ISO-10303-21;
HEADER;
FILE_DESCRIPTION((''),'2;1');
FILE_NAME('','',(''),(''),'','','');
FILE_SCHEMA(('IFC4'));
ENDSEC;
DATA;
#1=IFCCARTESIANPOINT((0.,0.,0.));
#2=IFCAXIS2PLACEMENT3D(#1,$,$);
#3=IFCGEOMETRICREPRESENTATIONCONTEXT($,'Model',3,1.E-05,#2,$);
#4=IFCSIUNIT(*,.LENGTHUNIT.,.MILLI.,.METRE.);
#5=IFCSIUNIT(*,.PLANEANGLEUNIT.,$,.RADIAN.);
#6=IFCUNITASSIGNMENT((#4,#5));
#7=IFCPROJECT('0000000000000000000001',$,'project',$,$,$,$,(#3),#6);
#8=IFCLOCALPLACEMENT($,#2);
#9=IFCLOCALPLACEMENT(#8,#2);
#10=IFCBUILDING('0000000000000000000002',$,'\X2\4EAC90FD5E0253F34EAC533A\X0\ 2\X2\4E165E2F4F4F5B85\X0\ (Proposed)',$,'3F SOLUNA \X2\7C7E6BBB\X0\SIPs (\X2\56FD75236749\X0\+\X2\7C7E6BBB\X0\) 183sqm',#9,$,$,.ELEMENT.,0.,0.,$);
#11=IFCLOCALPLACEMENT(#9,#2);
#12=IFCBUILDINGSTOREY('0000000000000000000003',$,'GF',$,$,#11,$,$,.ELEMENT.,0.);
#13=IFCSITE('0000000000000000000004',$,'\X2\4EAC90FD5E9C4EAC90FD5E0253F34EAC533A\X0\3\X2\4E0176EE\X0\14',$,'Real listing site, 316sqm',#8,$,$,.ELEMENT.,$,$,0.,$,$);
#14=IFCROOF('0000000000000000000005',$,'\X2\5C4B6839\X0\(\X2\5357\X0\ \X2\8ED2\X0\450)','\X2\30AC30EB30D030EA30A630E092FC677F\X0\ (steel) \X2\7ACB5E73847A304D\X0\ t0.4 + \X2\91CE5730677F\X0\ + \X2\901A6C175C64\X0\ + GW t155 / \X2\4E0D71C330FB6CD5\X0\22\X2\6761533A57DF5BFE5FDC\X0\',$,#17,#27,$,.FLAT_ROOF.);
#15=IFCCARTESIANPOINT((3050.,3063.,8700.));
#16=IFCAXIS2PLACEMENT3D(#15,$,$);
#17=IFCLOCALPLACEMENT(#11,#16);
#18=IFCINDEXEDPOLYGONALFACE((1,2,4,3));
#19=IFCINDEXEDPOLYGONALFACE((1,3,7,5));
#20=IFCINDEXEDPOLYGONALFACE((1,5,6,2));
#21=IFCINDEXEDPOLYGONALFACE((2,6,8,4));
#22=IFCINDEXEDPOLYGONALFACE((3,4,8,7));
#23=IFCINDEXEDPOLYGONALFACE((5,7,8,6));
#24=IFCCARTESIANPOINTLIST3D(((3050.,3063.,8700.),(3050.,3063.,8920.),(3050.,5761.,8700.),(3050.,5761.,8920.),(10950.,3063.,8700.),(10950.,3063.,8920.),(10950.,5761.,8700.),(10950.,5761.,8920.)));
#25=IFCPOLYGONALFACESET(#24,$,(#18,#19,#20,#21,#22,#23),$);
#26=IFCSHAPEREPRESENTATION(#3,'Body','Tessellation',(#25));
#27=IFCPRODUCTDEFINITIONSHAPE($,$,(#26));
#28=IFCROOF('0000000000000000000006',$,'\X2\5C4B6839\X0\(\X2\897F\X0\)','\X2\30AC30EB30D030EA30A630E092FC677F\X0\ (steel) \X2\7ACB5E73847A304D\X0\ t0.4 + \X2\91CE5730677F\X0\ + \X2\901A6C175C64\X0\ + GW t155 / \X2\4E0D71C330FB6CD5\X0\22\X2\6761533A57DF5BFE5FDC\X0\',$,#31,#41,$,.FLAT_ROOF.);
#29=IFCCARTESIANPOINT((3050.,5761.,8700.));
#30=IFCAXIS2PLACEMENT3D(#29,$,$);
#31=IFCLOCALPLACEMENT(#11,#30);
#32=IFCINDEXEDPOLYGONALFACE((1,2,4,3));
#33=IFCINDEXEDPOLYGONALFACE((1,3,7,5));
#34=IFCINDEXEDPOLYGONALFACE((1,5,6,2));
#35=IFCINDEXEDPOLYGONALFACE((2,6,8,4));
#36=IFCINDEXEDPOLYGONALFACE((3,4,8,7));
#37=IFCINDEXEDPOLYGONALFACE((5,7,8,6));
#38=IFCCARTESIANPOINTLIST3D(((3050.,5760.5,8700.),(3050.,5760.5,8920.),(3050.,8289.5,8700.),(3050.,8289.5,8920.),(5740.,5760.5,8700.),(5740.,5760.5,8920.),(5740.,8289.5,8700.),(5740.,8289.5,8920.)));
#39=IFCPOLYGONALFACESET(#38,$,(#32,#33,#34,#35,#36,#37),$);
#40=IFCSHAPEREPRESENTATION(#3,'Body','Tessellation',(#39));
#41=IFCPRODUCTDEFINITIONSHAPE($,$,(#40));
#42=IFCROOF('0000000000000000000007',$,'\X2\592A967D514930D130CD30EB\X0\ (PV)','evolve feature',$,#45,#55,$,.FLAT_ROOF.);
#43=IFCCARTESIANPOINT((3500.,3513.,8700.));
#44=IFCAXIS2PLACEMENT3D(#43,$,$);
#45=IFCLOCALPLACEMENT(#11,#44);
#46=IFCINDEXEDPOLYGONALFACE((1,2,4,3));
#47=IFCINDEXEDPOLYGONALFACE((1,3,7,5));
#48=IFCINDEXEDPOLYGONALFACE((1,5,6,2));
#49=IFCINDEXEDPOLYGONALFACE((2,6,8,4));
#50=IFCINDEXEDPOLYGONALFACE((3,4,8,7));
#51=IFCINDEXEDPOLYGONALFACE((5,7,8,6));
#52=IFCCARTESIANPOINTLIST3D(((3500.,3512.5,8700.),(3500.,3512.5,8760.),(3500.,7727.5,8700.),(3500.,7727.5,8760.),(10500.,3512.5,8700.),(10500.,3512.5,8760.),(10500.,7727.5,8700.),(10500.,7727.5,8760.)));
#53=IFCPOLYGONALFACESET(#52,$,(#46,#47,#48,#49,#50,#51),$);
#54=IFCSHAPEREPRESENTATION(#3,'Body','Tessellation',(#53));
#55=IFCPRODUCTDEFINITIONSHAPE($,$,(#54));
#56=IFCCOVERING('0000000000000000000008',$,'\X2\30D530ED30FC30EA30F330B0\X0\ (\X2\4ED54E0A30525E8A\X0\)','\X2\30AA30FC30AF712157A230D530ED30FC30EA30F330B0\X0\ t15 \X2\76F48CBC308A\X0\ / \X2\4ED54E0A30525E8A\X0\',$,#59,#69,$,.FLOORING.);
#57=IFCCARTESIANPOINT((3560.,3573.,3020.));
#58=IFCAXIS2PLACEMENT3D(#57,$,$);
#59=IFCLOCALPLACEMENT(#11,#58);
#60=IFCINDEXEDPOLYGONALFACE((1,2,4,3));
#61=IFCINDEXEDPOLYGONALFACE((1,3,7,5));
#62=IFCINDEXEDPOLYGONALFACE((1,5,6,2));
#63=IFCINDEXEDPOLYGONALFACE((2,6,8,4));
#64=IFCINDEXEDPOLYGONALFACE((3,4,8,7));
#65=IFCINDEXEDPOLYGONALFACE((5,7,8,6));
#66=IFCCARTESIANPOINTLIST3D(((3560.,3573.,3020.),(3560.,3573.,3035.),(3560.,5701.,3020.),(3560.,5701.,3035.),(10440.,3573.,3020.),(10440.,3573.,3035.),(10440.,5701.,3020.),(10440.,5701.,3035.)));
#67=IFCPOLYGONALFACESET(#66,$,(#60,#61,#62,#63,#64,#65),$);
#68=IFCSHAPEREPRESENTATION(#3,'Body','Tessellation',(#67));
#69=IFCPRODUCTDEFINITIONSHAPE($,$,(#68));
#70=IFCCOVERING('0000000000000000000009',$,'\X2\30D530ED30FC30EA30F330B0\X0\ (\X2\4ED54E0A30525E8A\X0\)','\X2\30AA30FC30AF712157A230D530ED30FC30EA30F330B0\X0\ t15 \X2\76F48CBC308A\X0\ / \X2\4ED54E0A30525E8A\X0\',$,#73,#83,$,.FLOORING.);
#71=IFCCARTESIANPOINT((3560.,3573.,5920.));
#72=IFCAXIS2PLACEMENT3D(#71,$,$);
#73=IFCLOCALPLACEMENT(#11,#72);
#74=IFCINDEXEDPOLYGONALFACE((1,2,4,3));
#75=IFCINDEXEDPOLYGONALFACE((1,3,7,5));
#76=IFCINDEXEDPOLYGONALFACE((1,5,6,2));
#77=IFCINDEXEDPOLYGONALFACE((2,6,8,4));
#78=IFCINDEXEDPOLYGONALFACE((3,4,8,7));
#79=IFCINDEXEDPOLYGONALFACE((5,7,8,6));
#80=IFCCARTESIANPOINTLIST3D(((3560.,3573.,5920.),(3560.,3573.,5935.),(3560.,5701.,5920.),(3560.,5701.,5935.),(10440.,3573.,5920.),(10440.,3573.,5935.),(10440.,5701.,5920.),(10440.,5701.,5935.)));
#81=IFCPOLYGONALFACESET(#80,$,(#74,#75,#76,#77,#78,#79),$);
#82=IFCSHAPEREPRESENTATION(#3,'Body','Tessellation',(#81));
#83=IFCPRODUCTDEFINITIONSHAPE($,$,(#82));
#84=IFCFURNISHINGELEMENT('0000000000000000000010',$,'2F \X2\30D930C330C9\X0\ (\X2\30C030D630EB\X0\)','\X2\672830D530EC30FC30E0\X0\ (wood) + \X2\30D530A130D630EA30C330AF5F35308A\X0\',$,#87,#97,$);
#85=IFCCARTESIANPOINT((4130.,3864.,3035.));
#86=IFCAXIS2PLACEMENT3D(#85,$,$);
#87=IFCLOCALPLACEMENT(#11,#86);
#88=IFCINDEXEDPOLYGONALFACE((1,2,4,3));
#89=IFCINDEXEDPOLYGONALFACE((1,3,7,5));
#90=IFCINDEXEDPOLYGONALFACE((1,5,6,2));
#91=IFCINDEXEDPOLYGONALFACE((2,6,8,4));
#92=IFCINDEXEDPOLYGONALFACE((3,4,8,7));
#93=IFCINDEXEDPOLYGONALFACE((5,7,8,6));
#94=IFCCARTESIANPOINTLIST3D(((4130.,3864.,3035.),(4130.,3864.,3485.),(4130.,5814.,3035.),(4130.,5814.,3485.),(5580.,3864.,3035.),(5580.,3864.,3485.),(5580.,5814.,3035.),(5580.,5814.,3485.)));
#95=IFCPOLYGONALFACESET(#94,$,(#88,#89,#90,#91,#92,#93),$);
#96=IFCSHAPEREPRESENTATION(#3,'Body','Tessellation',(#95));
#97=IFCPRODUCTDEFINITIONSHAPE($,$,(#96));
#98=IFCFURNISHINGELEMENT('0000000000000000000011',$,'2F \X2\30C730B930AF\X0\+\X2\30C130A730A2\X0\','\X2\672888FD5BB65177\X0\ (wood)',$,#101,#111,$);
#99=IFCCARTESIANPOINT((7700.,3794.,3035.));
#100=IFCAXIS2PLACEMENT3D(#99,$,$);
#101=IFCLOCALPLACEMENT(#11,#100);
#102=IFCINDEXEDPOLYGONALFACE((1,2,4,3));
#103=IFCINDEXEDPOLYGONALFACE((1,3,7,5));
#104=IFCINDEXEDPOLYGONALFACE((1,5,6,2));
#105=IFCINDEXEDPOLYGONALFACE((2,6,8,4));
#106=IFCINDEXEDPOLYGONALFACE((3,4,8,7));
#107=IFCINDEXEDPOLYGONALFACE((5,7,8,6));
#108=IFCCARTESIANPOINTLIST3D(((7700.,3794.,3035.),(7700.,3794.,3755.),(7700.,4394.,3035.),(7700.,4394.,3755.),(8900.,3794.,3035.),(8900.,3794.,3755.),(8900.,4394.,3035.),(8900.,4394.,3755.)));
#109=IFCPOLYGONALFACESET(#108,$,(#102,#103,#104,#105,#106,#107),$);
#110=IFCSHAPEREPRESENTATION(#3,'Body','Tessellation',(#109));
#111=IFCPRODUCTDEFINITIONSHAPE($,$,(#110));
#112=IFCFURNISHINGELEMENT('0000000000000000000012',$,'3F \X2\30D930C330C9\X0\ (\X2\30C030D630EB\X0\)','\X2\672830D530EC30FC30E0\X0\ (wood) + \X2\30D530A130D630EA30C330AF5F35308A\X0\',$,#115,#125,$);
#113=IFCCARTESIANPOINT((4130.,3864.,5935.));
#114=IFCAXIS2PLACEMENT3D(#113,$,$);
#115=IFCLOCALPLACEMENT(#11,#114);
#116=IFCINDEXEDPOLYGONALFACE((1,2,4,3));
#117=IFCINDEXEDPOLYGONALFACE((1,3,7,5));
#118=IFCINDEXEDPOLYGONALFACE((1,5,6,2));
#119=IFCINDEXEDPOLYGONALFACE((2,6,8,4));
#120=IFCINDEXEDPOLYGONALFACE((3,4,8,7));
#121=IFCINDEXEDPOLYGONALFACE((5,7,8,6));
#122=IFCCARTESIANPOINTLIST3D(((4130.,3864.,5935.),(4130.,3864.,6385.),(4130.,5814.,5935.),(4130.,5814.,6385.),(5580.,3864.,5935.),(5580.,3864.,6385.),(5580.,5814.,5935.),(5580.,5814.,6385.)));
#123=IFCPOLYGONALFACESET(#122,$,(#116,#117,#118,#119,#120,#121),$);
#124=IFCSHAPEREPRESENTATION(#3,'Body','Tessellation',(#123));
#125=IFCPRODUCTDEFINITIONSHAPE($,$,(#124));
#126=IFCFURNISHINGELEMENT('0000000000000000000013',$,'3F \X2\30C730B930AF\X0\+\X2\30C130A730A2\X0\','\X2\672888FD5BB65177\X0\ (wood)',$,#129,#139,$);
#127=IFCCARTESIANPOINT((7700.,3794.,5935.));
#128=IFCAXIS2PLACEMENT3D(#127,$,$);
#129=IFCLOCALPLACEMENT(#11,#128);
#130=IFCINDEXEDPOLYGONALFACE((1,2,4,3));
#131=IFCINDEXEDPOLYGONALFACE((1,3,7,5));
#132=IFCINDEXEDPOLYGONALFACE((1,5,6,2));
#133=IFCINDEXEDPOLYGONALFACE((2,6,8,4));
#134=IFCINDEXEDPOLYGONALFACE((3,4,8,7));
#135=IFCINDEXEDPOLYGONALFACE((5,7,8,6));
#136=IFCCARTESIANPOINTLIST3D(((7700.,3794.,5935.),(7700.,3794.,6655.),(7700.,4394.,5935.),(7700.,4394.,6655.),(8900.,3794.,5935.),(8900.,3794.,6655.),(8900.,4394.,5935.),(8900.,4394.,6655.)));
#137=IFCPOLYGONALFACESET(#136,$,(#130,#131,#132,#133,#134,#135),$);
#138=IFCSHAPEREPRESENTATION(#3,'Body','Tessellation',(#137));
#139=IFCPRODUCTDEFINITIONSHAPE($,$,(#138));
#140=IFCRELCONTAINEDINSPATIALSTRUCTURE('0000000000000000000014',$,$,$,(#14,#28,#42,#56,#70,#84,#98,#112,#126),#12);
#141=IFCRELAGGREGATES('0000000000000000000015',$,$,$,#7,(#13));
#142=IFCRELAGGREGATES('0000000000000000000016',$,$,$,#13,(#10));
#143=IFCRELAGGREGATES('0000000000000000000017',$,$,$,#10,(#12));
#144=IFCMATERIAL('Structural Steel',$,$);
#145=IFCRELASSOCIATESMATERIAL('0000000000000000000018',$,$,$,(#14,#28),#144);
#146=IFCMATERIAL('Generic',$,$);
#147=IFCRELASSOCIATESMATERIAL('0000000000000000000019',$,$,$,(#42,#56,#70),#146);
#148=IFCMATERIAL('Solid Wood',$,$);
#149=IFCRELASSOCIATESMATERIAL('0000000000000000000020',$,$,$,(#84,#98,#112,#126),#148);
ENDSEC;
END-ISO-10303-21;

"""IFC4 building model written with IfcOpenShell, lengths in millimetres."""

from ifc_helpers import new_model, si_unit, frame, frame_2d, origin, place, context, project, spatial, rectangle, extrude, material, element, save


model = new_model("IFC4")

# Units and contexts
model_context = context("Model", 3, precision=1e-05, world=origin())
ifc_project = project(units=[si_unit("LENGTHUNIT", "METRE", prefix="MILLI"), si_unit("PLANEANGLEUNIT", "RADIAN")], contexts=[model_context])

# Site, building, storey
site_placement = place(None, origin())
site = spatial("IfcSite", under=ifc_project, at=site_placement, Name="京都府京都市右京区3丁目14", ObjectType="Real listing site, 316sqm", CompositionType="ELEMENT", RefElevation=0.0)
building_placement = place(site_placement, origin())
building = spatial("IfcBuilding", under=site, at=building_placement, Name="京都市右京区 2世帯住宅 (Proposed)", ObjectType="3F SOLUNA 籾殻SIPs (国産杉+籾殻) 183sqm", CompositionType="ELEMENT", ElevationOfRefHeight=0.0, ElevationOfTerrain=0.0)
storey_placement = place(building_placement, origin())
storey = spatial("IfcBuildingStorey", under=building, at=storey_placement, Name="GF", CompositionType="ELEMENT", Elevation=0.0)

# Shared definitions
ifc_material_1 = material(Name="Solid Wood")

# Roofs
ifc_material_2 = material(Name="Structural Steel")
roof_1_placement = place(storey_placement, frame((3050.0, 3063.0, 8700.0)))
element("IfcRoof", 1, at=roof_1_placement, inside=storey, material=ifc_material_2, Name="屋根(南 軒450)", Description="ガルバリウム鋼板 (steel) 立平葺き t0.4 + 野地板 + 通気層 + GW t155 / 不燃・法22条区域対応", PredefinedType="FLAT_ROOF", context=model_context, shape_type="SweptSolid", body=[
    extrude(rectangle(XDim=7900.0, YDim=2698.0, at=frame_2d((3950.0, 1349.0))), frame((3050.0, 3063.0, 8700.0)), (0.0, 0.0, 1.0), 220.0),
])
roof_2_placement = place(storey_placement, frame((3050.0, 5761.0, 8700.0)))
element("IfcRoof", 2, at=roof_2_placement, inside=storey, material=ifc_material_2, Name="屋根(西)", Description="ガルバリウム鋼板 (steel) 立平葺き t0.4 + 野地板 + 通気層 + GW t155 / 不燃・法22条区域対応", PredefinedType="FLAT_ROOF", context=model_context, shape_type="SweptSolid", body=[
    extrude(rectangle(XDim=2690.0, YDim=2529.0, at=frame_2d((1345.0, 1264.0))), frame((3050.0, 5761.0, 8700.0)), (0.0, 0.0, 1.0), 220.0),
])
ifc_material_3 = material(Name="Generic")
roof_3_placement = place(storey_placement, frame((3500.0, 3513.0, 8700.0)))
element("IfcRoof", 3, at=roof_3_placement, inside=storey, material=ifc_material_3, Name="太陽光パネル (PV)", Description="evolve feature", PredefinedType="FLAT_ROOF", context=model_context, shape_type="SweptSolid", body=[
    extrude(rectangle(XDim=7000.0, YDim=4215.0, at=frame_2d((3500.0, 2107.0))), frame((3500.0, 3513.0, 8700.0)), (0.0, 0.0, 1.0), 60.0),
])

# Coverings
covering_1_placement = place(storey_placement, frame((3560.0, 3573.0, 3020.0)))
element("IfcCovering", 4, at=covering_1_placement, inside=storey, material=ifc_material_3, Name="フローリング (仕上げ床)", Description="オーク無垢フローリング t15 直貼り / 仕上げ床", PredefinedType="FLOORING", context=model_context, shape_type="SweptSolid", body=[
    extrude(rectangle(XDim=6880.0, YDim=2128.0, at=frame_2d((3440.0, 1064.0))), frame((3560.0, 3573.0, 3020.0)), (0.0, 0.0, 1.0), 15.0),
])
covering_2_placement = place(storey_placement, frame((3560.0, 3573.0, 5920.0)))
element("IfcCovering", 5, at=covering_2_placement, inside=storey, material=ifc_material_3, Name="フローリング (仕上げ床)", Description="オーク無垢フローリング t15 直貼り / 仕上げ床", PredefinedType="FLOORING", context=model_context, shape_type="SweptSolid", body=[
    extrude(rectangle(XDim=6880.0, YDim=2128.0, at=frame_2d((3440.0, 1064.0))), frame((3560.0, 3573.0, 5920.0)), (0.0, 0.0, 1.0), 15.0),
])

# Furnishing elements
furnishing_1_placement = place(storey_placement, frame((4130.0, 3864.0, 3035.0)))
element("IfcFurnishingElement", 6, at=furnishing_1_placement, inside=storey, material=ifc_material_1, Name="2F ベッド (ダブル)", Description="木フレーム (wood) + ファブリック張り", context=model_context, shape_type="SweptSolid", body=[
    extrude(rectangle(XDim=1450.0, YDim=1950.0, at=frame_2d((725.0, 975.0))), frame((4130.0, 3864.0, 3035.0)), (0.0, 0.0, 1.0), 450.0),
])
furnishing_2_placement = place(storey_placement, frame((7700.0, 3794.0, 3035.0)))
element("IfcFurnishingElement", 7, at=furnishing_2_placement, inside=storey, material=ifc_material_1, Name="2F デスク+チェア", Description="木製家具 (wood)", context=model_context, shape_type="SweptSolid", body=[
    extrude(rectangle(XDim=1200.0, YDim=600.0, at=frame_2d((600.0, 300.0))), frame((7700.0, 3794.0, 3035.0)), (0.0, 0.0, 1.0), 720.0),
])
furnishing_3_placement = place(storey_placement, frame((4130.0, 3864.0, 5935.0)))
element("IfcFurnishingElement", 8, at=furnishing_3_placement, inside=storey, material=ifc_material_1, Name="3F ベッド (ダブル)", Description="木フレーム (wood) + ファブリック張り", context=model_context, shape_type="SweptSolid", body=[
    extrude(rectangle(XDim=1450.0, YDim=1950.0, at=frame_2d((725.0, 975.0))), frame((4130.0, 3864.0, 5935.0)), (0.0, 0.0, 1.0), 450.0),
])
furnishing_4_placement = place(storey_placement, frame((7700.0, 3794.0, 5935.0)))
element("IfcFurnishingElement", 9, at=furnishing_4_placement, inside=storey, material=ifc_material_1, Name="3F デスク+チェア", Description="木製家具 (wood)", context=model_context, shape_type="SweptSolid", body=[
    extrude(rectangle(XDim=1200.0, YDim=600.0, at=frame_2d((600.0, 300.0))), frame((7700.0, 3794.0, 5935.0)), (0.0, 0.0, 1.0), 720.0),
])

save(model, "model.ifc")
